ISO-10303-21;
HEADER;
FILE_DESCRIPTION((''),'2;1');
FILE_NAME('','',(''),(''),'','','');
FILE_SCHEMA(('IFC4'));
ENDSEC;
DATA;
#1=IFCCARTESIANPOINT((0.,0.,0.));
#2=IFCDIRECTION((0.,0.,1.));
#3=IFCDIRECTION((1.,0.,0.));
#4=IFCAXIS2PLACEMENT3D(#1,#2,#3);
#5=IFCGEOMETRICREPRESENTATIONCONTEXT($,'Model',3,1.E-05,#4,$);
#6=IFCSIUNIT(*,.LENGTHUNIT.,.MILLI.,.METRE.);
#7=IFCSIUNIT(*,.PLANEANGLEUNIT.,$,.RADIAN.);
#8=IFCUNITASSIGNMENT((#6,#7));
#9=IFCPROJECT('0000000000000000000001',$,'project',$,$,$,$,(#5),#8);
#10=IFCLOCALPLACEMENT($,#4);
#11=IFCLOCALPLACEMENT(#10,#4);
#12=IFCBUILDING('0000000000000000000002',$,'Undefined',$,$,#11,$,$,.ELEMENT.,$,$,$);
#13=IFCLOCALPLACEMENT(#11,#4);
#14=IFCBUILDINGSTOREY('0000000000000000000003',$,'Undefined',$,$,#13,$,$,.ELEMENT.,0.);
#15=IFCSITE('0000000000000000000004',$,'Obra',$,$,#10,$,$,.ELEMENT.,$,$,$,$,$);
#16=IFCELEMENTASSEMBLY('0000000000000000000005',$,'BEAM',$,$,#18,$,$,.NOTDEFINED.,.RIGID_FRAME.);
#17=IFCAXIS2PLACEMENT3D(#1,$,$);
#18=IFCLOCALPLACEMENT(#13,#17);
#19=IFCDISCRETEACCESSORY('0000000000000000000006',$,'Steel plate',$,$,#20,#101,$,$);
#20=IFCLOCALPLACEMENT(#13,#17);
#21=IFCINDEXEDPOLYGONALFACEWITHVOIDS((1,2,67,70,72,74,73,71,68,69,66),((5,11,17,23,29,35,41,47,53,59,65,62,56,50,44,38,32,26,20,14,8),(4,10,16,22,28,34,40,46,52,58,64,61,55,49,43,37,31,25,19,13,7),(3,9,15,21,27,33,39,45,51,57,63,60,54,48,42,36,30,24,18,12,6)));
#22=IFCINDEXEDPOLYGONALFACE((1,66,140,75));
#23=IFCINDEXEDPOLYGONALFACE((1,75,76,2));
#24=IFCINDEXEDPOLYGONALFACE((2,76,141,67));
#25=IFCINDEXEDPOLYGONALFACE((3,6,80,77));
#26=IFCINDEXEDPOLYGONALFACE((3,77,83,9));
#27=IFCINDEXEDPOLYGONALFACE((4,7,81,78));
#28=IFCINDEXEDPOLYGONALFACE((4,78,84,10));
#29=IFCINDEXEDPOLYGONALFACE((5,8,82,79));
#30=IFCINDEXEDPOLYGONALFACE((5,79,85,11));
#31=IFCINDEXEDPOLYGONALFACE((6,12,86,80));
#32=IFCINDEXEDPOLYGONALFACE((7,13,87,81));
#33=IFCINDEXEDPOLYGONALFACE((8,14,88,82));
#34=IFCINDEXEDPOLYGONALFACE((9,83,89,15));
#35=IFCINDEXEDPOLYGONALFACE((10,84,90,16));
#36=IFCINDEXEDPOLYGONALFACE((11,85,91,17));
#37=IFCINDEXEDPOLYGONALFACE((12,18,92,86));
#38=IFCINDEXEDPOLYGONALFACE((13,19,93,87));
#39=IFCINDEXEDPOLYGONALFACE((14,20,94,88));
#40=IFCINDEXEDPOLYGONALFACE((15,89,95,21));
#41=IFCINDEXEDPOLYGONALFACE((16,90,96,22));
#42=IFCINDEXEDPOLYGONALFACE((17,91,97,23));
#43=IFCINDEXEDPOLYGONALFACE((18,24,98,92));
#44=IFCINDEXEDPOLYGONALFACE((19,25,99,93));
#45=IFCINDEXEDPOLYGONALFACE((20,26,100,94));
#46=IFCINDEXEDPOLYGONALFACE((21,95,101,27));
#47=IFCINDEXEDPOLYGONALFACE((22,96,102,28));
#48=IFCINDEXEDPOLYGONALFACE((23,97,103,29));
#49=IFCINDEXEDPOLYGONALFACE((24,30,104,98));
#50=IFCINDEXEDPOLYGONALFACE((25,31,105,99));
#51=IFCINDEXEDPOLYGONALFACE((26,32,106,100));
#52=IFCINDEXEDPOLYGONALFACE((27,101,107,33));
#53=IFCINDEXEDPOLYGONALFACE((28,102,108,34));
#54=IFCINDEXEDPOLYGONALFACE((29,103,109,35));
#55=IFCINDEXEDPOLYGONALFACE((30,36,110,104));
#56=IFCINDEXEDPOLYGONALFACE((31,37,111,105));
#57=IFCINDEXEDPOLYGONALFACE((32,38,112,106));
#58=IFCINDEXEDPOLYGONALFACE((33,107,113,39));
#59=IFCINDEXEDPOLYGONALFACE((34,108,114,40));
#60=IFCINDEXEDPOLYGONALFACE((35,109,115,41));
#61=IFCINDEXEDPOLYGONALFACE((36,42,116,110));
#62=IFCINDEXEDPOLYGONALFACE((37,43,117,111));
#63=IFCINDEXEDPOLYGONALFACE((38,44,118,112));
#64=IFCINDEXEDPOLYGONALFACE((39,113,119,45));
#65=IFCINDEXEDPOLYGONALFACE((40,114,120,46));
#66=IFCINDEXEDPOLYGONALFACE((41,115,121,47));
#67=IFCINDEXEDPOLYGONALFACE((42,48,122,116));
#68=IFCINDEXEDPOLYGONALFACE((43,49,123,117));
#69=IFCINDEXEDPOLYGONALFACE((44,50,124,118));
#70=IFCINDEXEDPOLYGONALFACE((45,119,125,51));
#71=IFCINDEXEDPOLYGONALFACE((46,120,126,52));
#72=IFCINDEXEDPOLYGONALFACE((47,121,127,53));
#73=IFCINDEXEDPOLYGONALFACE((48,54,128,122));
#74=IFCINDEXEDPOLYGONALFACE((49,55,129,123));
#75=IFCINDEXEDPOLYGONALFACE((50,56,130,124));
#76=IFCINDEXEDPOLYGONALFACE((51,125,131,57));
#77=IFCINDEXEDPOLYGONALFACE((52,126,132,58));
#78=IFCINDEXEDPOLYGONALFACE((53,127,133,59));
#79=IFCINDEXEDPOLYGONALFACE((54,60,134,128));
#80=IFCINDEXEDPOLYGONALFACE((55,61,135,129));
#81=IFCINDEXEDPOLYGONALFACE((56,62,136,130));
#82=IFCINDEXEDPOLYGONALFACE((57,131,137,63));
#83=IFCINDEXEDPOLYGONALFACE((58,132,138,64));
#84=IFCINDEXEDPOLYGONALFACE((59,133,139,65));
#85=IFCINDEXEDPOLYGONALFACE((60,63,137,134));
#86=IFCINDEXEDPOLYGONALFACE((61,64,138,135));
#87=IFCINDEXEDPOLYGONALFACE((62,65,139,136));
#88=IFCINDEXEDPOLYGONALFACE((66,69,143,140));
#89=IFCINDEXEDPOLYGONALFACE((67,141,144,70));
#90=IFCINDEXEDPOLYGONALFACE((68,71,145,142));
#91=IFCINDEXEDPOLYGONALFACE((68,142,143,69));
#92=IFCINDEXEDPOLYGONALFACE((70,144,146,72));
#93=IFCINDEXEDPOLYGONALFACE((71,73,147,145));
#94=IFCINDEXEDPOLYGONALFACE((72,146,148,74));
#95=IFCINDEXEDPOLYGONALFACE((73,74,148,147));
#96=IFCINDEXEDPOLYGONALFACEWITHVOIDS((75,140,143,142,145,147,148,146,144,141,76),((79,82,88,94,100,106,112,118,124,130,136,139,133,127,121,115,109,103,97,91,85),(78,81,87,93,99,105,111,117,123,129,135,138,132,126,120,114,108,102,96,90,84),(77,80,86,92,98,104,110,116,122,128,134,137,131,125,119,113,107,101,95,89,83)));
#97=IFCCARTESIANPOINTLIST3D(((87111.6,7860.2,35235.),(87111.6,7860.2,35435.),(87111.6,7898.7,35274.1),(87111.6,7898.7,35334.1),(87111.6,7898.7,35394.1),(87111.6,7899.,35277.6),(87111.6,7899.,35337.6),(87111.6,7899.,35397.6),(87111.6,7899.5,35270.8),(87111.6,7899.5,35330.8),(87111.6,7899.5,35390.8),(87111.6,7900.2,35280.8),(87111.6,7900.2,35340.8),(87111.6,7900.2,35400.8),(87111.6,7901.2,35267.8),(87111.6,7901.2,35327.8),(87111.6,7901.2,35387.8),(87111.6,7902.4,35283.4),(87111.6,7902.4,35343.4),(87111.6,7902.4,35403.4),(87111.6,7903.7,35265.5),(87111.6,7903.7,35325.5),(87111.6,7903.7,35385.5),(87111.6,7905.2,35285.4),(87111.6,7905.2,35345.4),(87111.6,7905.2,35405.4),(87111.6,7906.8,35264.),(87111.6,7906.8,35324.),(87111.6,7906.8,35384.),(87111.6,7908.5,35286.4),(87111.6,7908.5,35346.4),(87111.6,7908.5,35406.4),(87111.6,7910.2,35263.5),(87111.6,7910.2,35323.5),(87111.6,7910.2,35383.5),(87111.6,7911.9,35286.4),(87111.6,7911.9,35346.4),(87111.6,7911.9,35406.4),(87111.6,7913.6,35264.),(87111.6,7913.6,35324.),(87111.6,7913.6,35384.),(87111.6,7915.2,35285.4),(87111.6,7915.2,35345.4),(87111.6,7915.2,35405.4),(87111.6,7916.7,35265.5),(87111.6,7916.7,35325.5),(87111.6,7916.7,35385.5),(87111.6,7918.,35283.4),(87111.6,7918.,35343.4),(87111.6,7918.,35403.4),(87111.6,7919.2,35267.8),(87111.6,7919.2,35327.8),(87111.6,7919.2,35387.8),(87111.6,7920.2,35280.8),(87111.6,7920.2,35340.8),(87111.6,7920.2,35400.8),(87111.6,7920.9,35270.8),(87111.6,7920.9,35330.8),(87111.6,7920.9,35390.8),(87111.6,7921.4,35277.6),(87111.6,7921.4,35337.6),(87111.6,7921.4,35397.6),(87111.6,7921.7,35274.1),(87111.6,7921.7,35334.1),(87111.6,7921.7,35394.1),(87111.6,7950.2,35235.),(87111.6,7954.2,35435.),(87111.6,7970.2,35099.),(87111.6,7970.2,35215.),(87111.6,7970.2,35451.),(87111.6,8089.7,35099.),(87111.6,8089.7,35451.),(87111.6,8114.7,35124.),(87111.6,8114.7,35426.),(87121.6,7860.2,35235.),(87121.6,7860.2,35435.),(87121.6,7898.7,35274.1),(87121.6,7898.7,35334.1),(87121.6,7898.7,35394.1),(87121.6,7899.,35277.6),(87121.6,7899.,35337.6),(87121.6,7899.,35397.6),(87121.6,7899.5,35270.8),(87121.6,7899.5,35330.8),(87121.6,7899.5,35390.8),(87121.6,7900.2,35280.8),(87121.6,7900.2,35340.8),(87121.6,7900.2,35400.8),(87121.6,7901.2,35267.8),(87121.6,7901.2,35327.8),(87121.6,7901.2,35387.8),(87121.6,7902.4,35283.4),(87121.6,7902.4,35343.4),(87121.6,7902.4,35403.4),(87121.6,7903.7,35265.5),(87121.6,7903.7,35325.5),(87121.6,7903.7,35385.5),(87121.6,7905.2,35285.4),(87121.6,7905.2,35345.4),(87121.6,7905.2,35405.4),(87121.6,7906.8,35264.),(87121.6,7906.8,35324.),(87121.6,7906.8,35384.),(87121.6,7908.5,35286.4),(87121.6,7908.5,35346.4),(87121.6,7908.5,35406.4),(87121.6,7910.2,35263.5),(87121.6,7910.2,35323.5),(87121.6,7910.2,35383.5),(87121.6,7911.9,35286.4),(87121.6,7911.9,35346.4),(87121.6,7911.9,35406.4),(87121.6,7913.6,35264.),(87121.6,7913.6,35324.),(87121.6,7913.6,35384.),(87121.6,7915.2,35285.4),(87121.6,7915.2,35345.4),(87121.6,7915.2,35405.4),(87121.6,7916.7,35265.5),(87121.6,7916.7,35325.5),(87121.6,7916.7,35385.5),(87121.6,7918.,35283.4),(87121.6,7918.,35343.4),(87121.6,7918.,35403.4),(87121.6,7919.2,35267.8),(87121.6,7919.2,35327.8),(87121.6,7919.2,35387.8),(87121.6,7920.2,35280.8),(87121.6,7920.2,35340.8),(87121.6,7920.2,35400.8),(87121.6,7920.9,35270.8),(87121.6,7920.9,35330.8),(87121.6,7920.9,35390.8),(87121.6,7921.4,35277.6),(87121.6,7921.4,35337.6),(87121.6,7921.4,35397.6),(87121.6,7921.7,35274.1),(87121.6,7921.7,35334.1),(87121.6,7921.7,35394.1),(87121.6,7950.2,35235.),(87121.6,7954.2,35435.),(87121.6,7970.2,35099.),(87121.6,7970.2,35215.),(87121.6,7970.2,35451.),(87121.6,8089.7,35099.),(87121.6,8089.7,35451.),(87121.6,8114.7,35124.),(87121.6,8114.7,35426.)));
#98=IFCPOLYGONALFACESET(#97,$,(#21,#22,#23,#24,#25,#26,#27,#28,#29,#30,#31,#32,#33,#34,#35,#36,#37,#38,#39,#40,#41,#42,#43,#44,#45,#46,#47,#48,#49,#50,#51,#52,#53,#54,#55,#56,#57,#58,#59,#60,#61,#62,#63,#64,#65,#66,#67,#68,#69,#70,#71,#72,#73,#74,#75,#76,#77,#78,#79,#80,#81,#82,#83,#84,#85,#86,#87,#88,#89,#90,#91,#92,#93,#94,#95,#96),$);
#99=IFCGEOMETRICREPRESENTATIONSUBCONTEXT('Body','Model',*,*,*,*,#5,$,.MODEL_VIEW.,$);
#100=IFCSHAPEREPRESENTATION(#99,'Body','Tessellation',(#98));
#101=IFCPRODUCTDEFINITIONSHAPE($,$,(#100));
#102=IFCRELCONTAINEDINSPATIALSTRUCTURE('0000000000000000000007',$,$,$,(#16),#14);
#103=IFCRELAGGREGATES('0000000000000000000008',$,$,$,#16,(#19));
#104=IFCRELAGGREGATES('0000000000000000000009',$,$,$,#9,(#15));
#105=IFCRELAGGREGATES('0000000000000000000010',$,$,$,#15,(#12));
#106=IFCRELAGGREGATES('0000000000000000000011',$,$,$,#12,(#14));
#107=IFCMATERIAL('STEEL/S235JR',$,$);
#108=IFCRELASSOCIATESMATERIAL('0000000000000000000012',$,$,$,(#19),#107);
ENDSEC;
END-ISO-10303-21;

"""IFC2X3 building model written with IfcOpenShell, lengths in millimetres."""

from ifc_helpers import new_model, si_unit, frame, origin_with_axes, origin_2d_with_axis, place, context, subcontext, project, spatial, polyline, circle, outline, extrude, source, transform, mapped, material, element, aggregate, save


model = new_model("IFC2X3")

# Units and contexts
model_context = context("Model", 3, precision=1e-05, world=origin_with_axes())
body_context = subcontext(model_context, "Body", "Model", "MODEL_VIEW")
ifc_project = project(units=[si_unit("LENGTHUNIT", "METRE", prefix="MILLI"), si_unit("PLANEANGLEUNIT", "RADIAN")], contexts=[model_context])

# Site, building, storey
site_placement = place(None, origin_with_axes())
site = spatial("IfcSite", under=ifc_project, at=site_placement, Name="Obra", CompositionType="ELEMENT")
building_placement = place(site_placement, origin_with_axes())
building = spatial("IfcBuilding", under=site, at=building_placement, Name="Undefined", CompositionType="ELEMENT")
storey_placement = place(building_placement, origin_with_axes())
storey = spatial("IfcBuildingStorey", under=building, at=storey_placement, Name="Undefined", CompositionType="ELEMENT", Elevation=0.0)

# Shared definitions
ifc_material_1 = material(Name="STEEL/S235JR")

# Element assembly
assembly_1_placement = place(storey_placement, origin_with_axes())
assembly_1 = element("IfcElementAssembly", 1, at=assembly_1_placement, inside=storey, Name="BEAM", AssemblyPlace="NOTDEFINED", PredefinedType="RIGID_FRAME")

# Discrete accessory, opening
discrete_accessory_1_placement = place(assembly_1_placement, frame((87116.6, 8114.7, 35124.0), z_axis=(-1.0, 0.0, 0.0), x_axis=(0.0, -0.707107, -0.707107)))
discrete_accessory_1 = element("IfcDiscreteAccessory", 2, at=discrete_accessory_1_placement, material=ifc_material_1, Name="Steel plate", context=body_context, shape_type="SweptSolid", body=[
    extrude(outline(polyline([(0.0, 0.0), (35.4, 0.0), (119.9, 84.5), (37.8, 166.5), (37.8, 194.8), (101.5, 258.4), (-40.0, 399.9), (-106.4, 333.4), (-129.0, 333.4), (-129.0, 333.4), (-213.5, 248.9), (-213.5, 213.5), (0.0, 0.0)])), frame((0.0, 0.0, -5.0), z_axis=(0.0, 0.0, 1.0), x_axis=(1.0, 0.0, 0.0)), (0.0, 0.0, 1.0), 10.0),
])
shared_shape_1 = source(origin_with_axes(), body_context, "Body", "SweptSolid", [
    extrude(circle(Radius=11.5, at=origin_2d_with_axis()), frame((0.0, -13.4, 0.0), z_axis=(0.0, 1.0, 0.0), x_axis=(1.0, 0.0, 0.0)), (0.0, 0.0, 1.0), 10.2),
])
opening_1_placement = place(assembly_1_placement, frame((87124.9, 7960.2, 35435.0), z_axis=(0.0, -1.0, 0.0), x_axis=(0.0, 0.0, -1.0)))
element("IfcOpeningElement", 3, at=opening_1_placement, cuts=discrete_accessory_1, ObjectType="Opening", context=body_context, shape_type="MappedRepresentation", body=[
    mapped(shared_shape_1, transform((40.0, 0.0, 50.0))),
    mapped(shared_shape_1, transform((100.0, 0.0, 50.0))),
    mapped(shared_shape_1, transform((160.0, 0.0, 50.0))),
])
aggregate(assembly_1, [discrete_accessory_1])

save(model, "model.ifc")
